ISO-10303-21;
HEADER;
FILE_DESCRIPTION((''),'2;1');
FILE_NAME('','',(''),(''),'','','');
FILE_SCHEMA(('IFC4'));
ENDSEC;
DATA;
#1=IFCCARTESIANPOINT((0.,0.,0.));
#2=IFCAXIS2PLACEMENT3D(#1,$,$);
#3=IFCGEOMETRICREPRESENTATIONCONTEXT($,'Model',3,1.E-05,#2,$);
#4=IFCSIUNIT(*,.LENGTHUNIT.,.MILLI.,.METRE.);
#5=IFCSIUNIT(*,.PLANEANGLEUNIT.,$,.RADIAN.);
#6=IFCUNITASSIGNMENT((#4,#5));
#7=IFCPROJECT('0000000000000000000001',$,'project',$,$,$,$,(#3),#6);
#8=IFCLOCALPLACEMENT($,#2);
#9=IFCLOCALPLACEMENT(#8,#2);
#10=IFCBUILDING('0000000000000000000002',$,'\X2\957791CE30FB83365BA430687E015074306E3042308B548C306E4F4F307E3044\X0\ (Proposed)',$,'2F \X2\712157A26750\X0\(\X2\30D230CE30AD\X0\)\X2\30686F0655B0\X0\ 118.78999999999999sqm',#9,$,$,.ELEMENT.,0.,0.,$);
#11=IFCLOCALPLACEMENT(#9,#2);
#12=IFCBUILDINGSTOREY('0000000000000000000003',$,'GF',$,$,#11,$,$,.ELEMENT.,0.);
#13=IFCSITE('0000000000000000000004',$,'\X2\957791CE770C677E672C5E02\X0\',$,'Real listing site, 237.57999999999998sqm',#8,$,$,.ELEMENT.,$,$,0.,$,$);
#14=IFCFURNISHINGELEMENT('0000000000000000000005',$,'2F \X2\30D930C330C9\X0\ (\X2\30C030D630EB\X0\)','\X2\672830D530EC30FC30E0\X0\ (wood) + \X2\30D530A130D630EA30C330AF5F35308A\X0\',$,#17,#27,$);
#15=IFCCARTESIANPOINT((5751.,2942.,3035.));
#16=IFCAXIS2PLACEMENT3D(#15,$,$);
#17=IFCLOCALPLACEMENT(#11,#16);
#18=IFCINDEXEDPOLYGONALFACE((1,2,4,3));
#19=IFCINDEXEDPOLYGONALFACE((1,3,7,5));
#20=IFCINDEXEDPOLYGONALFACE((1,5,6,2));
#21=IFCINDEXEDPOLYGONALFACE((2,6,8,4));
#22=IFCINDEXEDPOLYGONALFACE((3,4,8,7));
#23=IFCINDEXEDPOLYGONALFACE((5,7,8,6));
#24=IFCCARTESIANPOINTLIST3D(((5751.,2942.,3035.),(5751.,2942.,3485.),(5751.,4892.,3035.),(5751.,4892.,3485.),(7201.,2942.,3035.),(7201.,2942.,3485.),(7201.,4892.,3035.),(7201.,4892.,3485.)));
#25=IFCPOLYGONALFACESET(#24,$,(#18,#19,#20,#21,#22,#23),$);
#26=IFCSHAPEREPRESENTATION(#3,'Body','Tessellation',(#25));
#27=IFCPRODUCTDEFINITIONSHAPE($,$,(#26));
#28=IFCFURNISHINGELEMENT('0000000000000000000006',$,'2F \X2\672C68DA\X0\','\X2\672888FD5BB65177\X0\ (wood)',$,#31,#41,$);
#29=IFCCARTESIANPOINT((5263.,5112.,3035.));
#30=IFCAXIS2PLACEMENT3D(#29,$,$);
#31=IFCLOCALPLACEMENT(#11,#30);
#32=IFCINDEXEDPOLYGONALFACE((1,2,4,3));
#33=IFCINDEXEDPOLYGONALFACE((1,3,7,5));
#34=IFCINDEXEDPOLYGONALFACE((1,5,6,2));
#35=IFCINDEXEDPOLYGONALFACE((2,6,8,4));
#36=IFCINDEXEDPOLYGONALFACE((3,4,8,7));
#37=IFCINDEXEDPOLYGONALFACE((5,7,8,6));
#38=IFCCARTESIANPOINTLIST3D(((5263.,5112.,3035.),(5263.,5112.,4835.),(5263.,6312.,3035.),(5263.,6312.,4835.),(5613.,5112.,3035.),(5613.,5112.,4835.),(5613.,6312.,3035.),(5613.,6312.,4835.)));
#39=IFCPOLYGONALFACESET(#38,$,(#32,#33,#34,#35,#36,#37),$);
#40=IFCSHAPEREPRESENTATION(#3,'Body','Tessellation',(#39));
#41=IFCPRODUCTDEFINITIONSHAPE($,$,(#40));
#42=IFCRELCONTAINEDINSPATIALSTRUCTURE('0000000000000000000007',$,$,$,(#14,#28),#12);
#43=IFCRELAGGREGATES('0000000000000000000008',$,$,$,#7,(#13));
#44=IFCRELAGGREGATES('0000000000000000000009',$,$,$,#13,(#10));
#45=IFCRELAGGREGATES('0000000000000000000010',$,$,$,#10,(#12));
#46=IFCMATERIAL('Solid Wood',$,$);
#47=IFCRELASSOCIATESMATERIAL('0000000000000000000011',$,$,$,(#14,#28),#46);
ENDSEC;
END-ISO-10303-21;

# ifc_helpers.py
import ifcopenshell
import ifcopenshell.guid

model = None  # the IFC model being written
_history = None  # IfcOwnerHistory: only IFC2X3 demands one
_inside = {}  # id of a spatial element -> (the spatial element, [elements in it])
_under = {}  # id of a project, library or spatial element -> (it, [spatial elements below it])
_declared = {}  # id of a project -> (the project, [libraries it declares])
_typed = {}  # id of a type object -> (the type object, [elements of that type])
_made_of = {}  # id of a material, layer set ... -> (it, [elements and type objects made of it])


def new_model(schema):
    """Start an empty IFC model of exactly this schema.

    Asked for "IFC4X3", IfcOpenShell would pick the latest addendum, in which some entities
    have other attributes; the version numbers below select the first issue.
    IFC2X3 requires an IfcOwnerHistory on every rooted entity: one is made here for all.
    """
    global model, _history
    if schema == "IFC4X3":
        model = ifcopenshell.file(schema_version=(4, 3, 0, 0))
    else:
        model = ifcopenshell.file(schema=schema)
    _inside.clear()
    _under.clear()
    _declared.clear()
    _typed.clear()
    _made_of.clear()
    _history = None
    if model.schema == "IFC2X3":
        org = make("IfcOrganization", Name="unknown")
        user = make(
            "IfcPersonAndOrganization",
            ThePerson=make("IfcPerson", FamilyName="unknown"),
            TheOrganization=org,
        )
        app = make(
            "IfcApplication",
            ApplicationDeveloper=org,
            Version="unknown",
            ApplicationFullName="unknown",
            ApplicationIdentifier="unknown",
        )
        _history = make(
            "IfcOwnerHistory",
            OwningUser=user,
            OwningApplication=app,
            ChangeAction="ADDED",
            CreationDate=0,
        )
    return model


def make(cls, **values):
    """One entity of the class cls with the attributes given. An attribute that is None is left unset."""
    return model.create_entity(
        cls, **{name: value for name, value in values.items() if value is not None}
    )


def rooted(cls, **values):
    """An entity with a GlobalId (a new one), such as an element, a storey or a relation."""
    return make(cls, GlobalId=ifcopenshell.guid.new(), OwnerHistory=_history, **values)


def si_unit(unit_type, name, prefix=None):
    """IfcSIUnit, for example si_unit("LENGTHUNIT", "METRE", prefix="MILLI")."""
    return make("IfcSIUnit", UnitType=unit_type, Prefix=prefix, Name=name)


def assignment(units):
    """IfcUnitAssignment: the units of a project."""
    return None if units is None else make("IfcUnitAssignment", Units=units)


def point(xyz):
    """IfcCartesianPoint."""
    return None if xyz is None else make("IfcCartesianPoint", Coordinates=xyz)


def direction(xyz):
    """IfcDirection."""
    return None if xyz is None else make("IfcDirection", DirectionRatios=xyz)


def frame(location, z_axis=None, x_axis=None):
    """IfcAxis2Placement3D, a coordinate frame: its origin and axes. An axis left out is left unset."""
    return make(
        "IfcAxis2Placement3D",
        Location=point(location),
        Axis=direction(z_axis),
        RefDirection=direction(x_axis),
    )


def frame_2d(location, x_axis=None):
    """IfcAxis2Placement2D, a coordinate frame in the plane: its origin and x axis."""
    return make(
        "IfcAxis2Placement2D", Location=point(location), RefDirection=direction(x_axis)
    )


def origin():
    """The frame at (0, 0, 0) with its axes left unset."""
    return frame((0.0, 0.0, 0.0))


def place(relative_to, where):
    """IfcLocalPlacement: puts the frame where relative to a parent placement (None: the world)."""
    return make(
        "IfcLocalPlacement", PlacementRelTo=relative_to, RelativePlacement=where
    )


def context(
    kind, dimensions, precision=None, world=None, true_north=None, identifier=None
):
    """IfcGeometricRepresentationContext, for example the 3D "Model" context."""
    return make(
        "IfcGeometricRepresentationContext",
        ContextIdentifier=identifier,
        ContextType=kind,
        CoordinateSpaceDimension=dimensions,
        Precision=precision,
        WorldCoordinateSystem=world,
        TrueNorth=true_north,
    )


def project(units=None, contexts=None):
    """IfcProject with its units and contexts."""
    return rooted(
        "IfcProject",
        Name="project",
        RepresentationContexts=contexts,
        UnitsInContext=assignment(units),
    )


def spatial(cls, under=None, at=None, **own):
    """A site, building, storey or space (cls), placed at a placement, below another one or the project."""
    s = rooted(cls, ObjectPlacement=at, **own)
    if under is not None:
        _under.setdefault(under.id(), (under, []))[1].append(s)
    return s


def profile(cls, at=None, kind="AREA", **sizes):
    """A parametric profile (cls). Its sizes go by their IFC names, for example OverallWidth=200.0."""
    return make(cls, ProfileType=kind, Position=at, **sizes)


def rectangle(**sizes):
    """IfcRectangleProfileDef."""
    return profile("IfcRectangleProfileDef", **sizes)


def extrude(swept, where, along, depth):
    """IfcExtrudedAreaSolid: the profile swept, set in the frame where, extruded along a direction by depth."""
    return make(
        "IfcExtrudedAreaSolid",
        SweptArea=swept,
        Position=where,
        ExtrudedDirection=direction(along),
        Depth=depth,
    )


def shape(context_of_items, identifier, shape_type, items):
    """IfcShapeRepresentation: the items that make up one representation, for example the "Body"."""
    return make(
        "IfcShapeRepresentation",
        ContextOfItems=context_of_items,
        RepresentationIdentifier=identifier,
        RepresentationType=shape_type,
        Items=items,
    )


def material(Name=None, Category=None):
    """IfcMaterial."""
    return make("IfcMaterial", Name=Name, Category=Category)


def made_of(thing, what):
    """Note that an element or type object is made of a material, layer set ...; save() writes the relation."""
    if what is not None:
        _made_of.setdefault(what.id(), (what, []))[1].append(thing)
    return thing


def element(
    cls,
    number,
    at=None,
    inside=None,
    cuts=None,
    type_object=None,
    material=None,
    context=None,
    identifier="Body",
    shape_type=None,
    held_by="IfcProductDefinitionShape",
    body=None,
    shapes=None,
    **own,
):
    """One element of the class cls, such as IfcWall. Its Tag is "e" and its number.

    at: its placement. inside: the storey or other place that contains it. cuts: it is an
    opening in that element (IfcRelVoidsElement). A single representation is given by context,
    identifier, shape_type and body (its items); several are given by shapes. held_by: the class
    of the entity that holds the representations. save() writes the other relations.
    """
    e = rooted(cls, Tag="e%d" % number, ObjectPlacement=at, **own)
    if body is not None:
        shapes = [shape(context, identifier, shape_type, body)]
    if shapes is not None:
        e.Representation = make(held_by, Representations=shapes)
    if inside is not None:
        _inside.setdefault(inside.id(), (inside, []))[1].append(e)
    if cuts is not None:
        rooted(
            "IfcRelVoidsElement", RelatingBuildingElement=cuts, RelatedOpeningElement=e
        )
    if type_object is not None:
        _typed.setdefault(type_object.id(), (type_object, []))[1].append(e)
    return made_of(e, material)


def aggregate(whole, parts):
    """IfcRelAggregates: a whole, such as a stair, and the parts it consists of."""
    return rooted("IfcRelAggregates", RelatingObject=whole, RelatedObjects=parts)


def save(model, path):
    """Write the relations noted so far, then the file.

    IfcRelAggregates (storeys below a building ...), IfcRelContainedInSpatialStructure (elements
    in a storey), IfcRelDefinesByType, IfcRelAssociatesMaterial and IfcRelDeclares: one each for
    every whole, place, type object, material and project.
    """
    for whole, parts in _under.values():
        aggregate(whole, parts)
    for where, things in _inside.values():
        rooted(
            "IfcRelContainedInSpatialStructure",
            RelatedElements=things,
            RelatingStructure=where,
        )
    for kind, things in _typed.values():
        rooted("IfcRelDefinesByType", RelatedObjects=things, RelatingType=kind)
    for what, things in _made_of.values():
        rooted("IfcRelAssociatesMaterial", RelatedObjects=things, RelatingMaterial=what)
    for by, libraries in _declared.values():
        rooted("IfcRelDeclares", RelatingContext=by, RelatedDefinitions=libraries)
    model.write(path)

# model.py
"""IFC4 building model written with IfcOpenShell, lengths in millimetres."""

from ifc_helpers import new_model, si_unit, frame, frame_2d, origin, place, context, project, spatial, rectangle, extrude, material, element, save


model = new_model("IFC4")

# Units and contexts
model_context = context("Model", 3, precision=1e-05, world=origin())
ifc_project = project(units=[si_unit("LENGTHUNIT", "METRE", prefix="MILLI"), si_unit("PLANEANGLEUNIT", "RADIAN")], contexts=[model_context])

# Site, building, storey
site_placement = place(None, origin())
site = spatial("IfcSite", under=ifc_project, at=site_placement, Name="長野県松本市", ObjectType="Real listing site, 237.57999999999998sqm", CompositionType="ELEMENT", RefElevation=0.0)
building_placement = place(site_placement, origin())
building = spatial("IfcBuilding", under=site, at=building_placement, Name="長野・茶室と縁側のある和の住まい (Proposed)", ObjectType="2F 無垢材(ヒノキ)と漆喰 118.78999999999999sqm", CompositionType="ELEMENT", ElevationOfRefHeight=0.0, ElevationOfTerrain=0.0)
storey_placement = place(building_placement, origin())
storey = spatial("IfcBuildingStorey", under=building, at=storey_placement, Name="GF", CompositionType="ELEMENT", Elevation=0.0)

# Shared definitions
ifc_material_1 = material(Name="Solid Wood")

# Furnishing elements
furnishing_1_placement = place(storey_placement, frame((5751.0, 2942.0, 3035.0)))
element("IfcFurnishingElement", 1, at=furnishing_1_placement, inside=storey, material=ifc_material_1, Name="2F ベッド (ダブル)", Description="木フレーム (wood) + ファブリック張り", context=model_context, shape_type="SweptSolid", body=[
    extrude(rectangle(XDim=1450.0, YDim=1950.0, at=frame_2d((725.0, 975.0))), frame((5751.0, 2942.0, 3035.0)), (0.0, 0.0, 1.0), 450.0),
])
furnishing_2_placement = place(storey_placement, frame((5263.0, 5112.0, 3035.0)))
element("IfcFurnishingElement", 2, at=furnishing_2_placement, inside=storey, material=ifc_material_1, Name="2F 本棚", Description="木製家具 (wood)", context=model_context, shape_type="SweptSolid", body=[
    extrude(rectangle(XDim=350.0, YDim=1200.0, at=frame_2d((175.0, 600.0))), frame((5263.0, 5112.0, 3035.0)), (0.0, 0.0, 1.0), 1800.0),
])

save(model, "model.ifc")
